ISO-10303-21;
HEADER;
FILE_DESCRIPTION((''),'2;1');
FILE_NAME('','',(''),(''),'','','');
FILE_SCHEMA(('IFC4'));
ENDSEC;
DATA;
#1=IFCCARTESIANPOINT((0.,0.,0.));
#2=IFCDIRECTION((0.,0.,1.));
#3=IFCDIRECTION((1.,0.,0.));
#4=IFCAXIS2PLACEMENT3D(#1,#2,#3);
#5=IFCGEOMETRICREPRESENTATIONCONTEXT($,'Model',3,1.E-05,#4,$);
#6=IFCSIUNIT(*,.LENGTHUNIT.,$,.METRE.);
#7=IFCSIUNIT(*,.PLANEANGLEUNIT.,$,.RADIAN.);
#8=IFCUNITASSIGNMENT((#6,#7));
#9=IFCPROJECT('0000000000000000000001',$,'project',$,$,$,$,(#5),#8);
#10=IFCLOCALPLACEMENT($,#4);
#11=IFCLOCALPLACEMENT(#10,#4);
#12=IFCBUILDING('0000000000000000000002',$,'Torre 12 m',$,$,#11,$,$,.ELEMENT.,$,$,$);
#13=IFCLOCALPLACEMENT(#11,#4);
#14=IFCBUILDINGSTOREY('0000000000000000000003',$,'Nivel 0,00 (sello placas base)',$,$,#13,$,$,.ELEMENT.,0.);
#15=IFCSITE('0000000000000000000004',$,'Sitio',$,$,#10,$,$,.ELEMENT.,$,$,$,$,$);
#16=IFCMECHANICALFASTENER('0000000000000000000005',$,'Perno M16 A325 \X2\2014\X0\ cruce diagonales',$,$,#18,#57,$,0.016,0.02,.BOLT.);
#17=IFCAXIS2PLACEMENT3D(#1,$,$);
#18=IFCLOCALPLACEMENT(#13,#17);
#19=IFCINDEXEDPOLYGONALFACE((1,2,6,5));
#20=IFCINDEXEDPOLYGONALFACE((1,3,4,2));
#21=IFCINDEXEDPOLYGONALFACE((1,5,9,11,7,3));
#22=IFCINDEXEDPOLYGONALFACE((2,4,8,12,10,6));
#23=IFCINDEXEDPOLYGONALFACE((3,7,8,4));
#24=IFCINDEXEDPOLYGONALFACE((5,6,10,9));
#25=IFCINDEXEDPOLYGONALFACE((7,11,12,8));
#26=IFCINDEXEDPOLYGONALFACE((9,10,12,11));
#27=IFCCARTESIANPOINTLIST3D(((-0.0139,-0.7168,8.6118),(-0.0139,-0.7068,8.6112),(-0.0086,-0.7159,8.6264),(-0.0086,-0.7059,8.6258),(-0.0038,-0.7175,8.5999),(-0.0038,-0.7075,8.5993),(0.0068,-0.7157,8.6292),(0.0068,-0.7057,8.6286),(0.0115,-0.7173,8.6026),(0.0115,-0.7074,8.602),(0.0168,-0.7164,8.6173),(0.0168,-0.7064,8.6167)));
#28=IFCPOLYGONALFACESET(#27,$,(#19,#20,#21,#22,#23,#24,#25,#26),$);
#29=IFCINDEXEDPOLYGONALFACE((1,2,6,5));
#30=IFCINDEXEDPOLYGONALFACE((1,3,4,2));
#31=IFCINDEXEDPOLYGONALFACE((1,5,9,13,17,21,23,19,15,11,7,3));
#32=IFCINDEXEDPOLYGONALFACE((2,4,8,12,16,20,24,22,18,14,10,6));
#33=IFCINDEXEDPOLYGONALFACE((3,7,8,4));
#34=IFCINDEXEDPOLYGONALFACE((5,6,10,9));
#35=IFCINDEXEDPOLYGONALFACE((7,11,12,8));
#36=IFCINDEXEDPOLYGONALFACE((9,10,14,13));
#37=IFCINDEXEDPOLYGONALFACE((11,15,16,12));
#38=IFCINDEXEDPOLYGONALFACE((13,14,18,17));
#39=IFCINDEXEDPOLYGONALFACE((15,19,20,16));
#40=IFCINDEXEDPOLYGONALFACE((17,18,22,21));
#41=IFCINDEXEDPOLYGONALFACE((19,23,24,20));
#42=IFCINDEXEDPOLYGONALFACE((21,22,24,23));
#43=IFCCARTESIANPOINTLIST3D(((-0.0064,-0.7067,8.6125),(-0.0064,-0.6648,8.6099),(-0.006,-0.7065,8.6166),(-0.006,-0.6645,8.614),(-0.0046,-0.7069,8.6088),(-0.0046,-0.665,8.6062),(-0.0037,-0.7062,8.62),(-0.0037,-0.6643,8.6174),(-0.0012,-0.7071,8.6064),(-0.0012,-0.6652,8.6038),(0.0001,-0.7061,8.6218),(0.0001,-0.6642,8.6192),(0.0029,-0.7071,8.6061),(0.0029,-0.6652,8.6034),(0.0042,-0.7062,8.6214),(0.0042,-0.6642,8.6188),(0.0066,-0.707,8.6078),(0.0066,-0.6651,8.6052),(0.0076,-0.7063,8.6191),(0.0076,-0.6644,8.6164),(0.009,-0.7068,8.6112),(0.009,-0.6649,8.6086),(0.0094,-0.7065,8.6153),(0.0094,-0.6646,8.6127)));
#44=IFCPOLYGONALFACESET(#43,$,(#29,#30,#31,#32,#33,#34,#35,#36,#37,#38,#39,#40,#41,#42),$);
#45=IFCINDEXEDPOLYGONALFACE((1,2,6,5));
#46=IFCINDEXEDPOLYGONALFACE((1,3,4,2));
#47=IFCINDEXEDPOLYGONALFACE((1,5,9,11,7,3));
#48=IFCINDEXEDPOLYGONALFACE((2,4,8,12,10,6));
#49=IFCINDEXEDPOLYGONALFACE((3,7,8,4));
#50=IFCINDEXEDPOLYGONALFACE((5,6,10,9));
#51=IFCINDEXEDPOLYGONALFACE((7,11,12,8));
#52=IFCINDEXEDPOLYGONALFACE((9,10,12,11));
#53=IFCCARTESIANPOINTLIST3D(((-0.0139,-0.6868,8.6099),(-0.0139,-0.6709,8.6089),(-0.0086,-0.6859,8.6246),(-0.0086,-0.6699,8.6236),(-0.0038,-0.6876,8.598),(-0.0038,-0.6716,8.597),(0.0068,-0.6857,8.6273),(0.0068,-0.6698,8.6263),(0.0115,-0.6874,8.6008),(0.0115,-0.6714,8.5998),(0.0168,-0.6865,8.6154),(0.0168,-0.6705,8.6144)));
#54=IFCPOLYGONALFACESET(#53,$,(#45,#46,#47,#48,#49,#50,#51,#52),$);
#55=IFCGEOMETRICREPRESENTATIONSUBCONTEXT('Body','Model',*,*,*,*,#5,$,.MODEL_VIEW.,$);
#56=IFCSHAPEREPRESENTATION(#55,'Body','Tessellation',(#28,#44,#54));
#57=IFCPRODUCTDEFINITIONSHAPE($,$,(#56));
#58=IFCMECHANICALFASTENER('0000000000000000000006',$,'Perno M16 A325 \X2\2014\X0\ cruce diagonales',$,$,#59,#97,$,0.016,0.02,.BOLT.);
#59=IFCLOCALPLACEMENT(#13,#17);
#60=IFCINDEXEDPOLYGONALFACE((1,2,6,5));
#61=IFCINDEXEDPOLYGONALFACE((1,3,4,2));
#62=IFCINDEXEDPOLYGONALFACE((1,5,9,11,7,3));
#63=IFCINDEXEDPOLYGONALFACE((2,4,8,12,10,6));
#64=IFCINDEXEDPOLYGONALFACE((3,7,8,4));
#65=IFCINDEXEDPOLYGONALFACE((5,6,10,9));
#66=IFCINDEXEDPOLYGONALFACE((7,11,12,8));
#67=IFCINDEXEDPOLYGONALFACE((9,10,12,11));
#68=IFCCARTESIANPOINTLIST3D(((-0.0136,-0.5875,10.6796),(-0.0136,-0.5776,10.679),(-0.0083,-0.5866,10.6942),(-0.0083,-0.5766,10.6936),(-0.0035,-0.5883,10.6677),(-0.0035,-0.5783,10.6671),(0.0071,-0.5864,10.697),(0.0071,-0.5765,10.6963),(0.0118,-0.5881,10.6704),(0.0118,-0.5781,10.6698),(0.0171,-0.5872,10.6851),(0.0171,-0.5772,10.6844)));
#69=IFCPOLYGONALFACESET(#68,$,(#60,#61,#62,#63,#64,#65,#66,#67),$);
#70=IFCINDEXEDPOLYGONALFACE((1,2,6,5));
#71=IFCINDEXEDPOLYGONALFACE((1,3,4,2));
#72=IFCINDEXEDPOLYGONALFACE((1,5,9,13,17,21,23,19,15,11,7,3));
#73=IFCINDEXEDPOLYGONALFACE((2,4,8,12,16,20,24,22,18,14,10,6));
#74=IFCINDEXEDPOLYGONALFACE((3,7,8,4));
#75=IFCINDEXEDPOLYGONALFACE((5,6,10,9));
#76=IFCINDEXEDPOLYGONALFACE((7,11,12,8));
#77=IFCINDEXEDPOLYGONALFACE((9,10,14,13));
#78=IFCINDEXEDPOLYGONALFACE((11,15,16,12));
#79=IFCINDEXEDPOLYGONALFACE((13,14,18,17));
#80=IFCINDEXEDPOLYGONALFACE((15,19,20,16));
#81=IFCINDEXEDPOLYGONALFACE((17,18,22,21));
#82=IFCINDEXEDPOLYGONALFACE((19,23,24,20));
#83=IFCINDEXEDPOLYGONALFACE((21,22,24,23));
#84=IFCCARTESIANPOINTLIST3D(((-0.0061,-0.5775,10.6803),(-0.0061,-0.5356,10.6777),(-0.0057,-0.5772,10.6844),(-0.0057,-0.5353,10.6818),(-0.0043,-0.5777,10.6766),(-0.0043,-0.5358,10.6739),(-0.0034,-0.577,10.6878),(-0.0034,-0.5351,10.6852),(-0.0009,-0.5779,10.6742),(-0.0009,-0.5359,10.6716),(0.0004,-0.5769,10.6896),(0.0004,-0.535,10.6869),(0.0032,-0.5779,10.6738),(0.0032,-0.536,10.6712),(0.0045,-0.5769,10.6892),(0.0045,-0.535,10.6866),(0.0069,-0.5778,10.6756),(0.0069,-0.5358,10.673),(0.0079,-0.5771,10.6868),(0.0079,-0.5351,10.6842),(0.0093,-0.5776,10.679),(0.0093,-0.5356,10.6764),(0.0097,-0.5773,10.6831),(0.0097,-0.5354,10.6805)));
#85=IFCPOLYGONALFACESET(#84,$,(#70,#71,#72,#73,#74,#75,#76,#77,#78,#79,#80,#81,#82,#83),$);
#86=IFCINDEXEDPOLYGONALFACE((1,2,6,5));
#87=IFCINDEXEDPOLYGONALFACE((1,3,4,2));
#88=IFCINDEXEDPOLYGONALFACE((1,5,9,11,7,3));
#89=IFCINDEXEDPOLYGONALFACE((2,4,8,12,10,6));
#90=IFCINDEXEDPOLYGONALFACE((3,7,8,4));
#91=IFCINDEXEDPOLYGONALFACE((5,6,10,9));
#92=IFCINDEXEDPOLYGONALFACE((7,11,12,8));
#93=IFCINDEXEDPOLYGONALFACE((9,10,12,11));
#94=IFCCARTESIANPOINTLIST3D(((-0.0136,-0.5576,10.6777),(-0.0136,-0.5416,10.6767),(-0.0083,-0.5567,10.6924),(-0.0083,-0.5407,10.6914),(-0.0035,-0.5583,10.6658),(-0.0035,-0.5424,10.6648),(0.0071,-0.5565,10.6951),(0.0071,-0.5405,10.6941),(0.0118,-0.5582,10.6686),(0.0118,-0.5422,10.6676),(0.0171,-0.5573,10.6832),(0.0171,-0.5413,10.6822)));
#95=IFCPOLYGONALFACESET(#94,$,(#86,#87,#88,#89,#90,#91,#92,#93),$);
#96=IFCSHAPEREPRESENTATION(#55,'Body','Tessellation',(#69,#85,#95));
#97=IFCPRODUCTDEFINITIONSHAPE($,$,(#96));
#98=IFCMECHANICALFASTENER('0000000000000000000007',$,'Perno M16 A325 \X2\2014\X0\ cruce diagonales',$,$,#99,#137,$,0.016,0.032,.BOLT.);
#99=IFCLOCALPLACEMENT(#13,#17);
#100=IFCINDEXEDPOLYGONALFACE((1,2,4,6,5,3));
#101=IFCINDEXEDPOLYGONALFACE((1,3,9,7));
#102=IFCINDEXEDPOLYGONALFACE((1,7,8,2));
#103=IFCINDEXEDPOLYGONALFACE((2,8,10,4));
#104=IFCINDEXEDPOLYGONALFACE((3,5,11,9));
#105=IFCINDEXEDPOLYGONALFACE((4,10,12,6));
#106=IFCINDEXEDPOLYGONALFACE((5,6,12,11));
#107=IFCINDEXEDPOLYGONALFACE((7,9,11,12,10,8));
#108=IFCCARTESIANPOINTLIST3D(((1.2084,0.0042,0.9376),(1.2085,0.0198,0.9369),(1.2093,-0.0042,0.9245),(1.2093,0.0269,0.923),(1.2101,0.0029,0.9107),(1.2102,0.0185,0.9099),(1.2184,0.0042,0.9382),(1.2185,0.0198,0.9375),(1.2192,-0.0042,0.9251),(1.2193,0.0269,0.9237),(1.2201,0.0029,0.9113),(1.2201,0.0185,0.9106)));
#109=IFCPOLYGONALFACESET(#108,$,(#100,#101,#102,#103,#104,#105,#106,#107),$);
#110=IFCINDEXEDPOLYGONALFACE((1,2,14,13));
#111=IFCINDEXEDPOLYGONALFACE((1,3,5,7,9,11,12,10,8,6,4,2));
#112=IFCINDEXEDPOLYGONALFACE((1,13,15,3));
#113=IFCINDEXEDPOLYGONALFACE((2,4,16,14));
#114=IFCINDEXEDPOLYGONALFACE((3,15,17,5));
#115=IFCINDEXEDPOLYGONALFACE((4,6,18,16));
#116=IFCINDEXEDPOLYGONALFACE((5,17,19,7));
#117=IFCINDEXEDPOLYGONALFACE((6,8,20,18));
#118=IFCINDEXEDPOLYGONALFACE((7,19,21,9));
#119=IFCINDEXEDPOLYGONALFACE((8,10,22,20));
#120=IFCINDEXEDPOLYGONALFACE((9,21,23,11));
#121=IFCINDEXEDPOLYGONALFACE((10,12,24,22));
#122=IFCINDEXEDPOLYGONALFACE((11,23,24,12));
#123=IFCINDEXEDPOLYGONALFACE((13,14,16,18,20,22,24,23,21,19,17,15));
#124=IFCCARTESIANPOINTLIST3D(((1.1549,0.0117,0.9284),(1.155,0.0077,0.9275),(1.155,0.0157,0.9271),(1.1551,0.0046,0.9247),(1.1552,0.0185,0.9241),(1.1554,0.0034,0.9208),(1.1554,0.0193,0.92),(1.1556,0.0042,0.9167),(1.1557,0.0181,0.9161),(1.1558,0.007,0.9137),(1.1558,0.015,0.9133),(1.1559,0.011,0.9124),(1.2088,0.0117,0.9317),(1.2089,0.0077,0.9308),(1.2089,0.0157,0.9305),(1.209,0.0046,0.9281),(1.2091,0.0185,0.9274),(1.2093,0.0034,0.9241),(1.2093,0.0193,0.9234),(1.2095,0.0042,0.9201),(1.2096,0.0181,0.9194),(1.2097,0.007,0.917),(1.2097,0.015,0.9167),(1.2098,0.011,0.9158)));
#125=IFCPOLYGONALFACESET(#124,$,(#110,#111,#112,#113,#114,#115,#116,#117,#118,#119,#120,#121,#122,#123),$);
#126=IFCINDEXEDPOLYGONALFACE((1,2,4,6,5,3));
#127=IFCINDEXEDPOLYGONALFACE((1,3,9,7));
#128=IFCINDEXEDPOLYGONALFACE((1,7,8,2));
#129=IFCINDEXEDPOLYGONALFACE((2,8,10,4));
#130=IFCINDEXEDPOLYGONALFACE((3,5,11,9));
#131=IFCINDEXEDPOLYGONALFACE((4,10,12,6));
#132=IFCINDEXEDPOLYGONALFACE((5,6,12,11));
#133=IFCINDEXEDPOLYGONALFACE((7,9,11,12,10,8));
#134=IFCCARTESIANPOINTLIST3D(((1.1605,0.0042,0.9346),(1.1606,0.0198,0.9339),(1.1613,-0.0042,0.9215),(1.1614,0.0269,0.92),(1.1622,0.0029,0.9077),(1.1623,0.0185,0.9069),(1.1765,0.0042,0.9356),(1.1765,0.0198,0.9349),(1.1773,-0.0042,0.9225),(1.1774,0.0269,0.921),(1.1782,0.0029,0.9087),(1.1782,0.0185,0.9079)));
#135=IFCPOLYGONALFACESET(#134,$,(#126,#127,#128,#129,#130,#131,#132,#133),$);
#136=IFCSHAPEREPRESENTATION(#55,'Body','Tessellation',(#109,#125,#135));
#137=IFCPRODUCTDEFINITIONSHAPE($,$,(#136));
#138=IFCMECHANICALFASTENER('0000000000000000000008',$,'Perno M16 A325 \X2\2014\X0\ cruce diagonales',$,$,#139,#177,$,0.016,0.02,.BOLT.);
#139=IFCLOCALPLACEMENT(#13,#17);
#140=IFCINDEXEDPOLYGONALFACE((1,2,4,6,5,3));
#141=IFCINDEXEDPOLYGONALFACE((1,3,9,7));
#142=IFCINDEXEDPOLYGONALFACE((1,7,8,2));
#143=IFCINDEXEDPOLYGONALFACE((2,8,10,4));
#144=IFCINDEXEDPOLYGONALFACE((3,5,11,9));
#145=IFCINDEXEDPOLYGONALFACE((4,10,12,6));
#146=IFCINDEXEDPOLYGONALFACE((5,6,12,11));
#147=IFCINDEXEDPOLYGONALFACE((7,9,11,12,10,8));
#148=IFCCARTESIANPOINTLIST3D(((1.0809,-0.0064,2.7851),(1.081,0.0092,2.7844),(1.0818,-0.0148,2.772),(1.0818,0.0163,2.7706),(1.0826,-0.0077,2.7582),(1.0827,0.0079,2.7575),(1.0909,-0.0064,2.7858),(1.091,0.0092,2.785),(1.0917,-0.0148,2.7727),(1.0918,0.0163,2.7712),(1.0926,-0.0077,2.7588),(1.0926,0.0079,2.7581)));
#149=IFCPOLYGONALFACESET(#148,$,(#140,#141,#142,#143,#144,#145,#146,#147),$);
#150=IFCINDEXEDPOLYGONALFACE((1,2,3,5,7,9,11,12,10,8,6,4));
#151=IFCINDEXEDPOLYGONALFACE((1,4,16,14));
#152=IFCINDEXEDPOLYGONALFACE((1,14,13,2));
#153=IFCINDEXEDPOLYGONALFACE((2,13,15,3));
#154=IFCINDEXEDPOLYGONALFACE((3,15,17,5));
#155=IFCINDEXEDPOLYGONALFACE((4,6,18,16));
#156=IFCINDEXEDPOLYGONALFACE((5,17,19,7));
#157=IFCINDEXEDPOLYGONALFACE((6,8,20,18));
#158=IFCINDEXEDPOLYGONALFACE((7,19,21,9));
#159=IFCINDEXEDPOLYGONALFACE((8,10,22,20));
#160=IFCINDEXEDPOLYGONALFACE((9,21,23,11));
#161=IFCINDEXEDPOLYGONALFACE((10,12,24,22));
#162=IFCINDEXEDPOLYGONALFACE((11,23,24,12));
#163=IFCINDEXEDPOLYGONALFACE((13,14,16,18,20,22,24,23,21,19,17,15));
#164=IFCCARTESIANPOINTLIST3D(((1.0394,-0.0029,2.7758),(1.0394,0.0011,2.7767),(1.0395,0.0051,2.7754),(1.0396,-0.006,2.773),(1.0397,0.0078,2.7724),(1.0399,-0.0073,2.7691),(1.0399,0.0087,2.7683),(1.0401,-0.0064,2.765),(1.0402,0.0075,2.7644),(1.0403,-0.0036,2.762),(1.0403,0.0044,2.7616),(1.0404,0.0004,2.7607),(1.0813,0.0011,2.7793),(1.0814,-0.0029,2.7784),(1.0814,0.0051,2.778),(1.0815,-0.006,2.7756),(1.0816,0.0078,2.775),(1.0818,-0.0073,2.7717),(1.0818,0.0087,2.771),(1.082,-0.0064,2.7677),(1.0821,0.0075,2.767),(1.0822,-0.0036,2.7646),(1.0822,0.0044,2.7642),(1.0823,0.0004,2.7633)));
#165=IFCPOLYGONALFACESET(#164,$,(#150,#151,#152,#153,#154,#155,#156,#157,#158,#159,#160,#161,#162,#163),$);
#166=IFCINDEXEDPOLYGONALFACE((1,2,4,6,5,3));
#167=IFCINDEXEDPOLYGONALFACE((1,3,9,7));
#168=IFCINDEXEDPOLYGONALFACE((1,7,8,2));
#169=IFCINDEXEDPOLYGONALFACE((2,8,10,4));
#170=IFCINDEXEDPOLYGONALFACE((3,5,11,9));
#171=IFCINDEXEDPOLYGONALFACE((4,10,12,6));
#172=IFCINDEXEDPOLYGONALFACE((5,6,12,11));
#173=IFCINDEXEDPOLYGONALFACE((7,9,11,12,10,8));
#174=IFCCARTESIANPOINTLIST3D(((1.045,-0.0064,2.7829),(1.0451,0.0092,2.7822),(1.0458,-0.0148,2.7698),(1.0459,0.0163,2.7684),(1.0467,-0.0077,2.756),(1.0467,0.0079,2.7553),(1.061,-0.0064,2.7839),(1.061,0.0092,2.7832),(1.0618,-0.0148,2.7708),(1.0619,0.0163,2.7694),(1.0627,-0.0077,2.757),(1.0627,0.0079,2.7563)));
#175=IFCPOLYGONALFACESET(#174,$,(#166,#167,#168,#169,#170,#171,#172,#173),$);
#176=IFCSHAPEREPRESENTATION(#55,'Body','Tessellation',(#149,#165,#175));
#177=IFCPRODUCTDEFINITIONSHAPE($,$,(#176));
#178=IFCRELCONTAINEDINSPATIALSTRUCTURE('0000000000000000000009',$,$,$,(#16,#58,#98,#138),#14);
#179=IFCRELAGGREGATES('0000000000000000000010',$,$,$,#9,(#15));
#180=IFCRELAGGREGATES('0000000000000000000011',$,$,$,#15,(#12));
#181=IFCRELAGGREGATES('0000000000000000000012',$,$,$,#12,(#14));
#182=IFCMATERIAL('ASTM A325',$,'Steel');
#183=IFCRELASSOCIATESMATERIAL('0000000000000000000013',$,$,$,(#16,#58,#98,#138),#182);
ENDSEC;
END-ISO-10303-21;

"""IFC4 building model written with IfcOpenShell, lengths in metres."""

from ifc_helpers import new_model, si_unit, frame, origin_with_axes, place, context, subcontext, project, spatial, polyline, outline, extrude, material, element, save


model = new_model("IFC4")

# Units and contexts
model_context = context("Model", 3, precision=1e-05, world=origin_with_axes())
body_context = subcontext(model_context, "Body", "Model", "MODEL_VIEW")
ifc_project = project(units=[si_unit("LENGTHUNIT", "METRE"), si_unit("PLANEANGLEUNIT", "RADIAN")], contexts=[model_context])

# Site, building, storey
site_placement = place(None, origin_with_axes())
site = spatial("IfcSite", under=ifc_project, at=site_placement, Name="Sitio", CompositionType="ELEMENT")
building_placement = place(site_placement, origin_with_axes())
building = spatial("IfcBuilding", under=site, at=building_placement, Name="Torre 12 m", CompositionType="ELEMENT")
storey_placement = place(building_placement, origin_with_axes())
storey = spatial("IfcBuildingStorey", under=building, at=storey_placement, Name="Nivel 0,00 (sello placas base)", CompositionType="ELEMENT", Elevation=0.0)

# Shared definitions
placement = place(storey_placement, origin_with_axes())

# Mechanical fasteners
ifc_material_1 = material(Name="ASTM A325", Category="Steel")
element("IfcMechanicalFastener", 1, at=placement, inside=storey, material=ifc_material_1, Name="Perno M16 A325 — cruce diagonales", NominalDiameter=0.016, NominalLength=0.02, PredefinedType="BOLT", context=body_context, shape_type="SweptSolid", body=[
    extrude(outline(polyline([(0.0135, 0.0078), (0.0, 0.0156), (-0.0135, 0.0078), (-0.0135, -0.0078), (0.0, -0.0156), (0.0135, -0.0078), (0.0135, 0.0078)])), frame((0.0015, -0.7166, 8.6145), z_axis=(0.0, 0.998053, -0.062378), x_axis=(0.940405, -0.021212, -0.339394)), (0.0, 0.0, 1.0), 0.01),
    extrude(outline(polyline([(0.008, 0.0), (0.0069, 0.004), (0.004, 0.0069), (0.0, 0.008), (-0.004, 0.0069), (-0.0069, 0.004), (-0.008, 0.0), (-0.0069, -0.004), (-0.004, -0.0069), (0.0, -0.008), (0.004, -0.0069), (0.0069, -0.004), (0.008, 0.0)])), frame((0.0015, -0.7066, 8.6139), z_axis=(0.0, 0.998053, -0.062378), x_axis=(0.940405, -0.021212, -0.339394)), (0.0, 0.0, 1.0), 0.042),
    extrude(outline(polyline([(0.0135, 0.0078), (0.0, 0.0156), (-0.0135, 0.0078), (-0.0135, -0.0078), (0.0, -0.0156), (0.0135, -0.0078), (0.0135, 0.0078)])), frame((0.0015, -0.6867, 8.6127), z_axis=(0.0, 0.998053, -0.062378), x_axis=(0.940405, -0.021212, -0.339394)), (0.0, 0.0, 1.0), 0.016),
])
element("IfcMechanicalFastener", 2, at=placement, inside=storey, material=ifc_material_1, Name="Perno M16 A325 — cruce diagonales", NominalDiameter=0.016, NominalLength=0.02, PredefinedType="BOLT", context=body_context, shape_type="SweptSolid", body=[
    extrude(outline(polyline([(0.0135, 0.0078), (0.0, 0.0156), (-0.0135, 0.0078), (-0.0135, -0.0078), (0.0, -0.0156), (0.0135, -0.0078), (0.0135, 0.0078)])), frame((0.0018, -0.5874, 10.6823), z_axis=(0.0, 0.998053, -0.062378), x_axis=(0.940405, -0.021212, -0.339394)), (0.0, 0.0, 1.0), 0.01),
    extrude(outline(polyline([(0.008, 0.0), (0.0069, 0.004), (0.004, 0.0069), (0.0, 0.008), (-0.004, 0.0069), (-0.0069, 0.004), (-0.008, 0.0), (-0.0069, -0.004), (-0.004, -0.0069), (0.0, -0.008), (0.004, -0.0069), (0.0069, -0.004), (0.008, 0.0)])), frame((0.0018, -0.5774, 10.6817), z_axis=(0.0, 0.998053, -0.062378), x_axis=(0.940405, -0.021212, -0.339394)), (0.0, 0.0, 1.0), 0.042),
    extrude(outline(polyline([(0.0135, 0.0078), (0.0, 0.0156), (-0.0135, 0.0078), (-0.0135, -0.0078), (0.0, -0.0156), (0.0135, -0.0078), (0.0135, 0.0078)])), frame((0.0018, -0.5574, 10.6805), z_axis=(0.0, 0.998053, -0.062378), x_axis=(0.940405, -0.021212, -0.339394)), (0.0, 0.0, 1.0), 0.016),
])
element("IfcMechanicalFastener", 3, at=placement, inside=storey, material=ifc_material_1, Name="Perno M16 A325 — cruce diagonales", NominalDiameter=0.016, NominalLength=0.032, PredefinedType="BOLT", context=body_context, shape_type="SweptSolid", body=[
    extrude(outline(polyline([(0.0135, 0.0078), (0.0, 0.0156), (-0.0135, 0.0078), (-0.0135, -0.0078), (0.0, -0.0156), (0.0135, -0.0078), (0.0135, 0.0078)])), frame((1.2193, 0.0113, 0.9244), z_axis=(-0.998053, 0.0, -0.062378), x_axis=(0.033672, 0.841794, -0.538748)), (0.0, 0.0, 1.0), 0.01),
    extrude(outline(polyline([(0.008, 0.0), (0.0069, 0.004), (0.004, 0.0069), (0.0, 0.008), (-0.004, 0.0069), (-0.0069, 0.004), (-0.008, 0.0), (-0.0069, -0.004), (-0.004, -0.0069), (0.0, -0.008), (0.004, -0.0069), (0.0069, -0.004), (0.008, 0.0)])), frame((1.2093, 0.0113, 0.9238), z_axis=(-0.998053, 0.0, -0.062378), x_axis=(0.033672, 0.841794, -0.538748)), (0.0, 0.0, 1.0), 0.054),
    extrude(outline(polyline([(0.0135, 0.0078), (0.0, 0.0156), (-0.0135, 0.0078), (-0.0135, -0.0078), (0.0, -0.0156), (0.0135, -0.0078), (0.0135, 0.0078)])), frame((1.1774, 0.0113, 0.9218), z_axis=(-0.998053, 0.0, -0.062378), x_axis=(0.033672, 0.841794, -0.538748)), (0.0, 0.0, 1.0), 0.016),
])
element("IfcMechanicalFastener", 4, at=placement, inside=storey, material=ifc_material_1, Name="Perno M16 A325 — cruce diagonales", NominalDiameter=0.016, NominalLength=0.02, PredefinedType="BOLT", context=body_context, shape_type="SweptSolid", body=[
    extrude(outline(polyline([(0.0135, 0.0078), (0.0, 0.0156), (-0.0135, 0.0078), (-0.0135, -0.0078), (0.0, -0.0156), (0.0135, -0.0078), (0.0135, 0.0078)])), frame((1.0918, 0.0007, 2.7719), z_axis=(-0.998053, 0.0, -0.062378), x_axis=(0.033672, 0.841794, -0.538748)), (0.0, 0.0, 1.0), 0.01),
    extrude(outline(polyline([(0.008, 0.0), (0.0069, 0.004), (0.004, 0.0069), (0.0, 0.008), (-0.004, 0.0069), (-0.0069, 0.004), (-0.008, 0.0), (-0.0069, -0.004), (-0.004, -0.0069), (0.0, -0.008), (0.004, -0.0069), (0.0069, -0.004), (0.008, 0.0)])), frame((1.0818, 0.0007, 2.7713), z_axis=(-0.998053, 0.0, -0.062378), x_axis=(0.033672, 0.841794, -0.538748)), (0.0, 0.0, 1.0), 0.042),
    extrude(outline(polyline([(0.0135, 0.0078), (0.0, 0.0156), (-0.0135, 0.0078), (-0.0135, -0.0078), (0.0, -0.0156), (0.0135, -0.0078), (0.0135, 0.0078)])), frame((1.0618, 0.0007, 2.7701), z_axis=(-0.998053, 0.0, -0.062378), x_axis=(0.033672, 0.841794, -0.538748)), (0.0, 0.0, 1.0), 0.016),
])

save(model, "model.ifc")
